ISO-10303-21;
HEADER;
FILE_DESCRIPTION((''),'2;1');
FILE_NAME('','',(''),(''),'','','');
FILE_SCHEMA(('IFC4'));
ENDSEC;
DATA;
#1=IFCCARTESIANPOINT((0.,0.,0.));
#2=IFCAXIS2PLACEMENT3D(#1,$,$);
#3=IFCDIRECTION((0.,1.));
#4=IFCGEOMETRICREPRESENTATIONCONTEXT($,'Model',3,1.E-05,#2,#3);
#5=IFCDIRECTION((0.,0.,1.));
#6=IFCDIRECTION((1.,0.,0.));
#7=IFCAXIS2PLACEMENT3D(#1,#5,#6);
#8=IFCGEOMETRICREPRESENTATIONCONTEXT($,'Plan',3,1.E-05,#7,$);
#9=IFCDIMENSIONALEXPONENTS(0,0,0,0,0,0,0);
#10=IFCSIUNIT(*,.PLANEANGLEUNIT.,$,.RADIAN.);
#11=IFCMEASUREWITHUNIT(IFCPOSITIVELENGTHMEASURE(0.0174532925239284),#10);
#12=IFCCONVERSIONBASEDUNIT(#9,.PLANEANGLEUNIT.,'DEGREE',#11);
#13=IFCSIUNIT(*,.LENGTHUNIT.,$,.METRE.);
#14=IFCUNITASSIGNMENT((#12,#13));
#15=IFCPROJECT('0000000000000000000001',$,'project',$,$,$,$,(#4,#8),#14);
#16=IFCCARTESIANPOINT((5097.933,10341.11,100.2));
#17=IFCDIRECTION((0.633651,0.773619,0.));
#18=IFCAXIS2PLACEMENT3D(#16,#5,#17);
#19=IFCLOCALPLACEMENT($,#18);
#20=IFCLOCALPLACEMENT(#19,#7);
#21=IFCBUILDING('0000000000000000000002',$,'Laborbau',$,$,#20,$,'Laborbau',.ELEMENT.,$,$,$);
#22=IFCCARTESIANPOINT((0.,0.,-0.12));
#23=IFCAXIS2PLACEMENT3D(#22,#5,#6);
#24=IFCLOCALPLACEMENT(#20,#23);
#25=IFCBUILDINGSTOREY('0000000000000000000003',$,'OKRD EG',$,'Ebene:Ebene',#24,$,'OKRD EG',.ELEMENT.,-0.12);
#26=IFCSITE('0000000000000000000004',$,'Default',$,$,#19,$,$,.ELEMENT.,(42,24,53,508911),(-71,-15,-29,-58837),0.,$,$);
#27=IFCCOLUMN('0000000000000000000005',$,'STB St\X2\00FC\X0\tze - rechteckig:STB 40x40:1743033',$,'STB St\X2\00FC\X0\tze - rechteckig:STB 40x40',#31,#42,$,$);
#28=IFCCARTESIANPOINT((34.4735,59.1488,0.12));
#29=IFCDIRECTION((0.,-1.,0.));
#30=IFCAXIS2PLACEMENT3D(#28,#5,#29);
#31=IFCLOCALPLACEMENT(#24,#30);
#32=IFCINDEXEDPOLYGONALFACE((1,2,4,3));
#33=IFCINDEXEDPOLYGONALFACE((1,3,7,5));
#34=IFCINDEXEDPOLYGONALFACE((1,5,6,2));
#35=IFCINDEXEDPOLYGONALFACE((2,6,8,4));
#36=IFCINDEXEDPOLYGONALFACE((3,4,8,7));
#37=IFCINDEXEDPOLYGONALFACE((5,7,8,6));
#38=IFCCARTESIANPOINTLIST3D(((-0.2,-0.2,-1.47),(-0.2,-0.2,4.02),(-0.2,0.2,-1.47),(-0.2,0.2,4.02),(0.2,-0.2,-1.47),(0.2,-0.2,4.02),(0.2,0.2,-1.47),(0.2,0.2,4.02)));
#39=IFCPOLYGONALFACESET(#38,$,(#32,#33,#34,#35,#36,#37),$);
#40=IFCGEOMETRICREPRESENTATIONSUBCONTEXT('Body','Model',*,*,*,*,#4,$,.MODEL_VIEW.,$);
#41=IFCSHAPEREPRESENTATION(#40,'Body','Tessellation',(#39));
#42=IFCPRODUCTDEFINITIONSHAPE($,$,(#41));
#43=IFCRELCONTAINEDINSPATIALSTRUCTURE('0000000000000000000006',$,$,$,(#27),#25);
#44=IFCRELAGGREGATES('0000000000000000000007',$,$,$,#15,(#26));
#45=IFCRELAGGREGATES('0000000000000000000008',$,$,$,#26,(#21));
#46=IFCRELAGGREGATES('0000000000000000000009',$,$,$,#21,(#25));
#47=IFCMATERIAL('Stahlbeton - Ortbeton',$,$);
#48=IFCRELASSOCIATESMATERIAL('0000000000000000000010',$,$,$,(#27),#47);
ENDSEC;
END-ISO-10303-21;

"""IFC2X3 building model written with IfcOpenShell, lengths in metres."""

from ifc_helpers import new_model, entity, si_unit, converted_unit, direction, frame, origin, origin_with_axes, origin_2d_with_axis, place, context, subcontext, project, spatial, rectangle, extrude, source, transform, mapped, material, element, save


model = new_model("IFC2X3")

# Units and contexts
model_context = context("Model", 3, precision=1e-05, world=origin(), true_north=direction((0.0, 1.0)))
plan_context = context("Plan", 3, precision=1e-05, world=origin_with_axes())
body_context = subcontext(model_context, "Body", "Model", "MODEL_VIEW")
ifc_project = project(units=[converted_unit("PLANEANGLEUNIT", "DEGREE", entity("IfcPositiveLengthMeasure", 0.0174532925239284), si_unit("PLANEANGLEUNIT", "RADIAN"), dimensions=[0, 0, 0, 0, 0, 0, 0]), si_unit("LENGTHUNIT", "METRE")], contexts=[model_context, plan_context])

# Site, building, storey
site_placement = place(None, frame((5097.933, 10341.11, 100.2), z_axis=(0.0, 0.0, 1.0), x_axis=(0.633651, 0.773619, 0.0)))
site = spatial("IfcSite", under=ifc_project, at=site_placement, Name="Default", CompositionType="ELEMENT", RefLatitude=(42, 24, 53, 508911), RefLongitude=(-71, -15, -29, -58837), RefElevation=0.0)
building_placement = place(site_placement, origin_with_axes())
building = spatial("IfcBuilding", under=site, at=building_placement, Name="Laborbau", LongName="Laborbau", CompositionType="ELEMENT")
storey_placement = place(building_placement, frame((0.0, 0.0, -0.12), z_axis=(0.0, 0.0, 1.0), x_axis=(1.0, 0.0, 0.0)))
storey = spatial("IfcBuildingStorey", under=building, at=storey_placement, Name="OKRD EG", ObjectType="Ebene:Ebene", LongName="OKRD EG", CompositionType="ELEMENT", Elevation=-0.12)

# Column
ifc_material_1 = material(Name="Stahlbeton - Ortbeton")
shared_shape = source(origin(), body_context, "Body", "SweptSolid", [
    extrude(rectangle(XDim=0.4, YDim=0.4, at=origin_2d_with_axis()), frame((0.0, 0.0, -1.47), z_axis=(0.0, 0.0, 1.0), x_axis=(0.0, -1.0, 0.0)), (0.0, 0.0, 1.0), 5.49),
])
column_placement = place(storey_placement, frame((34.4735, 59.1488, 0.12), z_axis=(0.0, 0.0, 1.0), x_axis=(0.0, -1.0, 0.0)))
element("IfcColumn", 1, at=column_placement, inside=storey, material=ifc_material_1, Name="STB Stütze - rechteckig:STB 40x40:1743033", ObjectType="STB Stütze - rechteckig:STB 40x40", context=body_context, shape_type="MappedRepresentation", body=[
    mapped(shared_shape, transform((0.0, 0.0, 0.0), scale=1.0)),
])

save(model, "model.ifc")
